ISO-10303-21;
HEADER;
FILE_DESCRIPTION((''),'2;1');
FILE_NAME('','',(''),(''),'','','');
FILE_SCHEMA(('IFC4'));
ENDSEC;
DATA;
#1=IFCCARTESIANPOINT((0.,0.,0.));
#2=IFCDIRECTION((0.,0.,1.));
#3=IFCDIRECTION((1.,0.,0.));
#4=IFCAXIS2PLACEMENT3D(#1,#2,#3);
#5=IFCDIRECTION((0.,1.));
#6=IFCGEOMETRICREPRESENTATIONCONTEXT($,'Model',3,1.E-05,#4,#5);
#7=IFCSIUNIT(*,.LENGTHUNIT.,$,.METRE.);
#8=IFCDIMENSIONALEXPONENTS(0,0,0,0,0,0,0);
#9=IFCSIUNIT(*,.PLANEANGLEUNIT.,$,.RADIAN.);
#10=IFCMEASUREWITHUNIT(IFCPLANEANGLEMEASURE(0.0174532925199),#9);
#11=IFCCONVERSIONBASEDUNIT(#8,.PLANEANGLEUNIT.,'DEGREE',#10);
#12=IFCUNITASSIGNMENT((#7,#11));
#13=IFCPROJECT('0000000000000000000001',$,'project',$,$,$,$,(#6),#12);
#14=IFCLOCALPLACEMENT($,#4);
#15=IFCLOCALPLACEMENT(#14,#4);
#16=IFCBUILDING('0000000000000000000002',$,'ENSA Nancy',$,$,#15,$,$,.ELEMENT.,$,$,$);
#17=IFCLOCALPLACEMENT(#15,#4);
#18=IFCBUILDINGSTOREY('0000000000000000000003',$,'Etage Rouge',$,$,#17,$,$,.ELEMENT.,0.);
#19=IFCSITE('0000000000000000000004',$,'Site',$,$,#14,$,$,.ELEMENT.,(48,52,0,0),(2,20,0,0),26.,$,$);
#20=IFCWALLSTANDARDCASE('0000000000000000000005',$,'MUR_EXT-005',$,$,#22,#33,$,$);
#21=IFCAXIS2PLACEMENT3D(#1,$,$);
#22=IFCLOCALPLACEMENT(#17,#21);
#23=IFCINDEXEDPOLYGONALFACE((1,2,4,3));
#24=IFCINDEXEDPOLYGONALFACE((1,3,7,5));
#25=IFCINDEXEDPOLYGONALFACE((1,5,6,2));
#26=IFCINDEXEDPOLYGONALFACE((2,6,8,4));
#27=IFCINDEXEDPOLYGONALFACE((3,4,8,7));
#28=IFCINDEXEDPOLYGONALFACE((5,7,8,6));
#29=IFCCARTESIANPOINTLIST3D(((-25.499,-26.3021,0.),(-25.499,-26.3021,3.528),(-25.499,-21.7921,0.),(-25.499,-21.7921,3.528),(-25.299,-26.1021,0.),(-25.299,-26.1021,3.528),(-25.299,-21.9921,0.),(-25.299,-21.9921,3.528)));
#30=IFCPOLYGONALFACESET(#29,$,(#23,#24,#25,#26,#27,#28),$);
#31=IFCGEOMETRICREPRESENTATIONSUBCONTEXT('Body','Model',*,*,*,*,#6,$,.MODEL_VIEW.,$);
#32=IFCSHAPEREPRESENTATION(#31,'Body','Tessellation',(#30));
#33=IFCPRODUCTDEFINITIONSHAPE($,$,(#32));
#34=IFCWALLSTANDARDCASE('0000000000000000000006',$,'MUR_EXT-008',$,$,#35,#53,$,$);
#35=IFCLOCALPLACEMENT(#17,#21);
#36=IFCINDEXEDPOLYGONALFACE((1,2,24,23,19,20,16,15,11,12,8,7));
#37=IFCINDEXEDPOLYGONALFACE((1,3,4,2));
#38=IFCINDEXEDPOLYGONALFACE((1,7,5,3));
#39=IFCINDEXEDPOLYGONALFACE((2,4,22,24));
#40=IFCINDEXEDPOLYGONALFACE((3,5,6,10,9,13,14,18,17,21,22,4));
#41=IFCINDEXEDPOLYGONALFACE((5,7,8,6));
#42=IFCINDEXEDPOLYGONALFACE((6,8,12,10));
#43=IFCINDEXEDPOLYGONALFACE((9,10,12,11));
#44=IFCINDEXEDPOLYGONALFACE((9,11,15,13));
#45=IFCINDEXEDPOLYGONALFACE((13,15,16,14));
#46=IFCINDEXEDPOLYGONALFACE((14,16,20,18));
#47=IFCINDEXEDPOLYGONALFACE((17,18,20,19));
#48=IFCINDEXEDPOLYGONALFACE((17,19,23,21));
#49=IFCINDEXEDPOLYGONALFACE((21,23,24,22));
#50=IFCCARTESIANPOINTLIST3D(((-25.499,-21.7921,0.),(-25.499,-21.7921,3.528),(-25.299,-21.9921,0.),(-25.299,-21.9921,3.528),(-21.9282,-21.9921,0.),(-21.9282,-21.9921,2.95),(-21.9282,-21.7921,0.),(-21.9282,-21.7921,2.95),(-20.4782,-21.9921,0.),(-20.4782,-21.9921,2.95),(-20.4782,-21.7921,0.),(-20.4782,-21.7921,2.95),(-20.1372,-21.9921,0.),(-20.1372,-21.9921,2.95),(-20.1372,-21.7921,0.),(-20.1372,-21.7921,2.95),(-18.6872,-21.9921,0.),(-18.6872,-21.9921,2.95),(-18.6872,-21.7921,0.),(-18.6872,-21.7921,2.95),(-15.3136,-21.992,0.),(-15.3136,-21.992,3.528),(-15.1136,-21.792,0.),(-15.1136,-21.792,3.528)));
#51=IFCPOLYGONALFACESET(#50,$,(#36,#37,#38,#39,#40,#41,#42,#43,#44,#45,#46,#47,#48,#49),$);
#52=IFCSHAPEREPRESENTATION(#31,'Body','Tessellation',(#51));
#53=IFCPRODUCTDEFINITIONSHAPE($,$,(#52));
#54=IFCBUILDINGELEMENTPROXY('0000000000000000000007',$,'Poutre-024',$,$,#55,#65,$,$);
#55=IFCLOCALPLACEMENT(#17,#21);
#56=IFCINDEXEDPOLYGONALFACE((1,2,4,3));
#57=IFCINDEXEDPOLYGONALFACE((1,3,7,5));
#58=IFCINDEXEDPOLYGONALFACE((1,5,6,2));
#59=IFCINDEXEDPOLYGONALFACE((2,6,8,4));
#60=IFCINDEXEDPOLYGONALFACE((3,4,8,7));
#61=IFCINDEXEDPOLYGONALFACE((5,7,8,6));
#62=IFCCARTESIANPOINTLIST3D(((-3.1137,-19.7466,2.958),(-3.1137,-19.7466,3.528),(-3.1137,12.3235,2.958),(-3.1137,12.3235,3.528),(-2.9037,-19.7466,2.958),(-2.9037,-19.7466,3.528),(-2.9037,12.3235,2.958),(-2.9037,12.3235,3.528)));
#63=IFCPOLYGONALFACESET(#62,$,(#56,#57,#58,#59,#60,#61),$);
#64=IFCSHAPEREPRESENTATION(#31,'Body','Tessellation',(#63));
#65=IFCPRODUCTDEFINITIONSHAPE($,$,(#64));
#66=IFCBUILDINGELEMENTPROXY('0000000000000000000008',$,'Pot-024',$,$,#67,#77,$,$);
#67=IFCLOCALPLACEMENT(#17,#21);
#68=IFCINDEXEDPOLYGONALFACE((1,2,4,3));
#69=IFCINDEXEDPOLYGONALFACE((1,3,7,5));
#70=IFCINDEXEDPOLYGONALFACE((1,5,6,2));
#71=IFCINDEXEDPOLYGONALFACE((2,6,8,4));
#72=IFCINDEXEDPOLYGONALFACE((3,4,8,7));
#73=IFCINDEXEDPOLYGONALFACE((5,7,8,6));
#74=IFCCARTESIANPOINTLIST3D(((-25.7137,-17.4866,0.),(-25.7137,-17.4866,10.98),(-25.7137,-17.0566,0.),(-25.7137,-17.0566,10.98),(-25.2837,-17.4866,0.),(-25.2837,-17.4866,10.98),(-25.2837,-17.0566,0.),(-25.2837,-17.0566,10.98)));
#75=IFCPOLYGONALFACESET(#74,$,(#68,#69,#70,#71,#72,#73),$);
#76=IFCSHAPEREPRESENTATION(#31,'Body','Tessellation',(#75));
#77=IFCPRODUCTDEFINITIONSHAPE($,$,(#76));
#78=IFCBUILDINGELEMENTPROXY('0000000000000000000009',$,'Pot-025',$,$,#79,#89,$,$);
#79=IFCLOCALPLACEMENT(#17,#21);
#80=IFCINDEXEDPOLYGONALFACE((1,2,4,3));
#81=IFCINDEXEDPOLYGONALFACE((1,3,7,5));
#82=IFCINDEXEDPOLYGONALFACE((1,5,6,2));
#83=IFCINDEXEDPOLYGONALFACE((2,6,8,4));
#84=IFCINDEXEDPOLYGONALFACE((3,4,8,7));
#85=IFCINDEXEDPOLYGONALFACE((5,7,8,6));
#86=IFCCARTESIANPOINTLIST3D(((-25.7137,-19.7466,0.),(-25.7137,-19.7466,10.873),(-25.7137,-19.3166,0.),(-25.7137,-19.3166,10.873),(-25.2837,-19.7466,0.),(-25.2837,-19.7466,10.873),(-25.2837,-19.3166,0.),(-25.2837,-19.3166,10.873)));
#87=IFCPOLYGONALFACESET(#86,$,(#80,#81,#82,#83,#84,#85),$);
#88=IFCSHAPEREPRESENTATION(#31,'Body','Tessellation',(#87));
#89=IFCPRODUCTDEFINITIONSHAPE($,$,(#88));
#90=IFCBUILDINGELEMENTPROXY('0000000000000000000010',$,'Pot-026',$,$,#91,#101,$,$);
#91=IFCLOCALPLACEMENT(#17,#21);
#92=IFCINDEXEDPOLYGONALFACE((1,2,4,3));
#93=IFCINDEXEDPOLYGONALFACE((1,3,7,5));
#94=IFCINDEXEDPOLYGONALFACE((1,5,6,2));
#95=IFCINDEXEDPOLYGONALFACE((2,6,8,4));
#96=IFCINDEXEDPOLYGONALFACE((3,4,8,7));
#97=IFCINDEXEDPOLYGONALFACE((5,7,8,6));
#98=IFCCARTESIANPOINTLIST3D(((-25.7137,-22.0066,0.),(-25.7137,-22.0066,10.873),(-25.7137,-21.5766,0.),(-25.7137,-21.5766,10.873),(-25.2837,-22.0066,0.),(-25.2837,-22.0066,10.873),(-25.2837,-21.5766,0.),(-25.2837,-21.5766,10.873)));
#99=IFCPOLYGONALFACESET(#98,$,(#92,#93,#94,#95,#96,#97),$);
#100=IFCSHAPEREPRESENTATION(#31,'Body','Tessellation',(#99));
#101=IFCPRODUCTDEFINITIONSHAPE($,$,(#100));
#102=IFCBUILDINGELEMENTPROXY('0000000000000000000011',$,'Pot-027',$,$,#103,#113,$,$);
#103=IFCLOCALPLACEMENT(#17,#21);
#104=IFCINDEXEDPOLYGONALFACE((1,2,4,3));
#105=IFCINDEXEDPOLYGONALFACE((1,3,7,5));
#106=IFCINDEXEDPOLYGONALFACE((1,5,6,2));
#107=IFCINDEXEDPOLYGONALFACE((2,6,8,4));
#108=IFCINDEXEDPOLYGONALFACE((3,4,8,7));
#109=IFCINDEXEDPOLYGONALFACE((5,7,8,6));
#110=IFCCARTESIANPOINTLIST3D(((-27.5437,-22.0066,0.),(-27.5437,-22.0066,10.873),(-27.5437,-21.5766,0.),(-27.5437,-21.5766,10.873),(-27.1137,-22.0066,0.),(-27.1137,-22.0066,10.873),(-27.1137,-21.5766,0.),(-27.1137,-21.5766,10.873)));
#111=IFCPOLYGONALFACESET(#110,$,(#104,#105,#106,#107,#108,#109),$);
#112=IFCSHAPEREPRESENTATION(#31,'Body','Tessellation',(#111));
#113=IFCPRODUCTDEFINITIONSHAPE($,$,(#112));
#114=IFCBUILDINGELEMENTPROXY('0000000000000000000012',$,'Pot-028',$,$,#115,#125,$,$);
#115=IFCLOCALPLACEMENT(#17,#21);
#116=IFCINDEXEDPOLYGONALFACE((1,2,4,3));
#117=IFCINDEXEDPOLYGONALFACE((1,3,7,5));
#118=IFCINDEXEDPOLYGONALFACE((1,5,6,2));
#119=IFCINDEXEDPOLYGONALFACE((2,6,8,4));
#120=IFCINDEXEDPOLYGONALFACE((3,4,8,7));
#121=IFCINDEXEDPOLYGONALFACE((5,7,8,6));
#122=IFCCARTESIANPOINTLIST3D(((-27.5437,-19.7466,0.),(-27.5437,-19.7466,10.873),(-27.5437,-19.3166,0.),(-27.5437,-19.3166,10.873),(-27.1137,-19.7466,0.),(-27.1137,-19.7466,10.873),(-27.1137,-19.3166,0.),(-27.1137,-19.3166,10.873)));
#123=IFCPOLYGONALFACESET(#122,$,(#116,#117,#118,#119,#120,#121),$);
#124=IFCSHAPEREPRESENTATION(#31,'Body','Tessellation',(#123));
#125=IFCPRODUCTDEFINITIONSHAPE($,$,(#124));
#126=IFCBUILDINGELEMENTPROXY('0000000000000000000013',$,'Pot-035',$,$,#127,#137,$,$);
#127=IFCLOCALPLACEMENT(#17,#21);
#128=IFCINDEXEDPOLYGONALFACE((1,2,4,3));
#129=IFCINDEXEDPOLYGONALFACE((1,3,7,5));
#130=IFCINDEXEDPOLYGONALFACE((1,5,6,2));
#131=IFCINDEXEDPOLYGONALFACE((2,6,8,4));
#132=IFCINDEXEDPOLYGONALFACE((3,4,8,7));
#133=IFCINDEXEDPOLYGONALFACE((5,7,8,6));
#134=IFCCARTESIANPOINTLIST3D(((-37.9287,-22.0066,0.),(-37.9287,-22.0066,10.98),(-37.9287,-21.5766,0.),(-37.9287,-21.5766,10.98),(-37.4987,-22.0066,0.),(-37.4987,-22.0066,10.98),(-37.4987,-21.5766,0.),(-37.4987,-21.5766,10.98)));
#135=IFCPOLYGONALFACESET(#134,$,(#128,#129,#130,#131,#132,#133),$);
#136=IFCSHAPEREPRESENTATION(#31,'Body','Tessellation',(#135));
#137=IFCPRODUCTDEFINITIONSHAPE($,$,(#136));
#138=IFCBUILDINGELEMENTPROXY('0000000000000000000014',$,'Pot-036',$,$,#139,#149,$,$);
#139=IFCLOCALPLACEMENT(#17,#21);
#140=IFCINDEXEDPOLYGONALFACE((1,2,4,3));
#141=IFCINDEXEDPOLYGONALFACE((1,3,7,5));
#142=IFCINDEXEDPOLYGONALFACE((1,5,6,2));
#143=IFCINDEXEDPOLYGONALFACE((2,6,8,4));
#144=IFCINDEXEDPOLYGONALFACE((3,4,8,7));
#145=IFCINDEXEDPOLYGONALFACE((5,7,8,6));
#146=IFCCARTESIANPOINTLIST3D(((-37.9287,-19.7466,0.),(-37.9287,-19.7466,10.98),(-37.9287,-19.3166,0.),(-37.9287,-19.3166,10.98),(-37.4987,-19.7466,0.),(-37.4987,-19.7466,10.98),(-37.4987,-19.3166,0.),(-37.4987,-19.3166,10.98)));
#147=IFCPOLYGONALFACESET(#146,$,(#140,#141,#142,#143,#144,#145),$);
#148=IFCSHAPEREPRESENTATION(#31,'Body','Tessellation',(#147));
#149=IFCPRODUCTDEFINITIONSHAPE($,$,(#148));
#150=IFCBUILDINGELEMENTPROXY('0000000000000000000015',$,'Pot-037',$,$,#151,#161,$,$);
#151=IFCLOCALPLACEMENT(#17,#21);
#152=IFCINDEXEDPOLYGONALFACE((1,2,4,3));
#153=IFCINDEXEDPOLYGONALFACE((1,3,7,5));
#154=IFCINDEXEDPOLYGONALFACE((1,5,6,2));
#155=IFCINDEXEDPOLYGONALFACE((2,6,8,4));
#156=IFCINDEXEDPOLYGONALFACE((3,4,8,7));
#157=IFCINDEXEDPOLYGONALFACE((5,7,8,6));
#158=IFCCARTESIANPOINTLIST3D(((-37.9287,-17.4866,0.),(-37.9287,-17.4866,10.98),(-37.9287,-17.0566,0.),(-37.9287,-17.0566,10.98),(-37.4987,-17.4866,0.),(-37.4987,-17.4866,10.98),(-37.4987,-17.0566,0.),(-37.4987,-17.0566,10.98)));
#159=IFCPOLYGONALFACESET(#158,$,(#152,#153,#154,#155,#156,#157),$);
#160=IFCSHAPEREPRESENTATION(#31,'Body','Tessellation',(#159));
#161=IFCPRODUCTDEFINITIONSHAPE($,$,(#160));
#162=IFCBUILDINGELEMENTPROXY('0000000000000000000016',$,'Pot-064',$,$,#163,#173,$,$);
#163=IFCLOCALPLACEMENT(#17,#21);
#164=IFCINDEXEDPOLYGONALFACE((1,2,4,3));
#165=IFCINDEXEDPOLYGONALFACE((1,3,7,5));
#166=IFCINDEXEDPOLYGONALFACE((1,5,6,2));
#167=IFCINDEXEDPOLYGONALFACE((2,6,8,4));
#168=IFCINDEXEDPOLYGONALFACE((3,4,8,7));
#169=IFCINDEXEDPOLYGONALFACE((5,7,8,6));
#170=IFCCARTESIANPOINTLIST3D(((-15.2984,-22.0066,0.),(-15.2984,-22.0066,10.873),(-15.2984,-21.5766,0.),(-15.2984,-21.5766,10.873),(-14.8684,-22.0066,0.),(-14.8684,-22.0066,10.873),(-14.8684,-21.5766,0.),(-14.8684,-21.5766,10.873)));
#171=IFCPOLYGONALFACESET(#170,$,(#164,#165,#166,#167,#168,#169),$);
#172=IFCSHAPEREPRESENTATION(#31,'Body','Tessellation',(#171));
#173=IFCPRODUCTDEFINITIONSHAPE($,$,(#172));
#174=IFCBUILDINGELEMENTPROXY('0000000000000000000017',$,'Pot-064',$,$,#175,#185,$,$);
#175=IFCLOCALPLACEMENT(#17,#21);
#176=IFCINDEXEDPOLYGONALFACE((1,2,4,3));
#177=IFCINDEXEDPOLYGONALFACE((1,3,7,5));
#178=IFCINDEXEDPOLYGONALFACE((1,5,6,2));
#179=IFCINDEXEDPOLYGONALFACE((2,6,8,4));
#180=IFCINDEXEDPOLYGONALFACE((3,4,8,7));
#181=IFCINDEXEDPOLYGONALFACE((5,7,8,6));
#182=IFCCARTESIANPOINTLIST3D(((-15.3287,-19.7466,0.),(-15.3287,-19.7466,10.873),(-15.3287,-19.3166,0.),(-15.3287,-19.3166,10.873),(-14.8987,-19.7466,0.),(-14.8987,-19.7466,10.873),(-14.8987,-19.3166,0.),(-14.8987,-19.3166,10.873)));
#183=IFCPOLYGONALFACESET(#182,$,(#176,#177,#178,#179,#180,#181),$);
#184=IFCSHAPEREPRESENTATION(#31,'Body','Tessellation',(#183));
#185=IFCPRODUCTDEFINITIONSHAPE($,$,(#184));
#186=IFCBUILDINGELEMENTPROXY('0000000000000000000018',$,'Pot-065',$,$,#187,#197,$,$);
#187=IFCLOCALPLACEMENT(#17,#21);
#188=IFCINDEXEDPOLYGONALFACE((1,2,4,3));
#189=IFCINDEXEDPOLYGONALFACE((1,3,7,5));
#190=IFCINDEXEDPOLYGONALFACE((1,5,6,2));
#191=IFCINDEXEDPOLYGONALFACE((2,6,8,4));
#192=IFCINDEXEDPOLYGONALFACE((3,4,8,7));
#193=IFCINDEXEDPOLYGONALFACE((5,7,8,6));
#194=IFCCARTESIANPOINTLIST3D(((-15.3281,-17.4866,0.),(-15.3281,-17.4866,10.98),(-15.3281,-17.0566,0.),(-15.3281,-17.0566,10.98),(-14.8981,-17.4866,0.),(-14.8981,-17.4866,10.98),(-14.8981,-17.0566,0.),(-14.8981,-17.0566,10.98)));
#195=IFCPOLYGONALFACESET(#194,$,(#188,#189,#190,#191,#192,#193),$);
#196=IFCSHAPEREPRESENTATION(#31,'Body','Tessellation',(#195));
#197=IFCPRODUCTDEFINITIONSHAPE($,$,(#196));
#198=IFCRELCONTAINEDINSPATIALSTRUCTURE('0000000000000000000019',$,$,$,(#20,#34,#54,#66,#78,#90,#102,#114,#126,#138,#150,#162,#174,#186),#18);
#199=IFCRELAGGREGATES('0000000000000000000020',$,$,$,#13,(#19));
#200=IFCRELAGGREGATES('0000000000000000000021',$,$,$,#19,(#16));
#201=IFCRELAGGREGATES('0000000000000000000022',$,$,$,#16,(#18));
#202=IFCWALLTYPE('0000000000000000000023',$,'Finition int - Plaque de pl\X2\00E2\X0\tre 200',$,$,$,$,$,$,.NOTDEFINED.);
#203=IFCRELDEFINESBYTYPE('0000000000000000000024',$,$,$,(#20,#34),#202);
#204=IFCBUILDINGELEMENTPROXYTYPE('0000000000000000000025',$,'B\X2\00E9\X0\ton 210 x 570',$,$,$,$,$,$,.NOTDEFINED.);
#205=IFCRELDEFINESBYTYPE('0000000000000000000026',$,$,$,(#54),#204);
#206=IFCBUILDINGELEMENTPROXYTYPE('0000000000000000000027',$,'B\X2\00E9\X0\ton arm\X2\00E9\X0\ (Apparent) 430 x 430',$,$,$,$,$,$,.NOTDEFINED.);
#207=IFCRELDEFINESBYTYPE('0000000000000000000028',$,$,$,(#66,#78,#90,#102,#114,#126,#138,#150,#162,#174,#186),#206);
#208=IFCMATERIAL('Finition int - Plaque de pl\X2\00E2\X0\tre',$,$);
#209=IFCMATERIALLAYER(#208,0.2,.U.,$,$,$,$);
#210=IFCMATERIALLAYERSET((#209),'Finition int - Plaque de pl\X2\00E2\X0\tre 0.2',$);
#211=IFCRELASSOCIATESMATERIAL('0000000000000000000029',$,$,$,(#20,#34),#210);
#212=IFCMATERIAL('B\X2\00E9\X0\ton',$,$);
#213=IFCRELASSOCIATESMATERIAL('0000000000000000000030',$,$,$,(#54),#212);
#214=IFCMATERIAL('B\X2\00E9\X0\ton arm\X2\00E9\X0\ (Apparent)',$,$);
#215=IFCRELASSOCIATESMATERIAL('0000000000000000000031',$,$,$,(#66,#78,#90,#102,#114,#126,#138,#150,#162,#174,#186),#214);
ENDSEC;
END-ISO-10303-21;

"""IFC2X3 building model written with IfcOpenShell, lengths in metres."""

from ifc_helpers import new_model, entity, si_unit, converted_unit, direction, frame, frame_2d, origin_with_axes, origin_2d_with_axis, place, context, subcontext, project, spatial, polyline, rectangle, outline, extrude, material, layer, layer_set, layer_usage, type_object, element, save


model = new_model("IFC2X3")

# Units and contexts
model_context = context("Model", 3, precision=1e-05, world=origin_with_axes(), true_north=direction((0.0, 1.0)))
body_context = subcontext(model_context, "Body", "Model", "MODEL_VIEW")
ifc_project = project(units=[si_unit("LENGTHUNIT", "METRE"), converted_unit("PLANEANGLEUNIT", "DEGREE", entity("IfcPlaneAngleMeasure", 0.0174532925199), si_unit("PLANEANGLEUNIT", "RADIAN"), dimensions=[0, 0, 0, 0, 0, 0, 0])], contexts=[model_context])

# Site, building, storey
site_placement = place(None, origin_with_axes())
site = spatial("IfcSite", under=ifc_project, at=site_placement, Name="Site", CompositionType="ELEMENT", RefLatitude=(48, 52, 0, 0), RefLongitude=(2, 20, 0, 0), RefElevation=26.0)
building_placement = place(site_placement, origin_with_axes())
building = spatial("IfcBuilding", under=site, at=building_placement, Name="ENSA Nancy", CompositionType="ELEMENT")
storey_placement = place(building_placement, origin_with_axes())
storey = spatial("IfcBuildingStorey", under=building, at=storey_placement, Name="Etage Rouge", CompositionType="ELEMENT", Elevation=0.0)

# Wall
ifc_material_1 = material(Name="Finition int - Plaque de plâtre")
ifc_layer = layer(ifc_material_1, 0.2, ventilated="UNKNOWN")
ifc_layer_set = layer_set([ifc_layer], Name="Finition int - Plaque de plâtre 0.2")
ifc_layer_usage_1 = layer_usage(ifc_layer_set, "AXIS2", "POSITIVE", 0.0)
wall_type = type_object("IfcWallType", Name="Finition int - Plaque de plâtre 200", PredefinedType="NOTDEFINED")
wall_1_placement = place(storey_placement, frame((-25.499, -21.7921, 0.0), z_axis=(0.0, 0.0, 1.0), x_axis=(0.0, -1.0, 0.0)))
element("IfcWallStandardCase", 1, at=wall_1_placement, inside=storey, type_object=wall_type, material=ifc_layer_usage_1, Name="MUR_EXT-005", context=body_context, shape_type="SweptSolid", body=[
    extrude(outline(polyline([(0.0, 0.0), (4.51, 0.0), (4.31, 0.2), (0.2, 0.2), (0.0, 0.0)])), origin_with_axes(), (0.0, 0.0, 1.0), 3.528),
])

# Wall, openings
ifc_layer_usage_2 = layer_usage(ifc_layer_set, "AXIS2", "POSITIVE", 0.0)
wall_2_placement = place(storey_placement, frame((-15.1136, -21.792, 0.0), z_axis=(0.0, 0.0, 1.0), x_axis=(-1.0, -0.000003, 0.0)))
wall_2 = element("IfcWallStandardCase", 2, at=wall_2_placement, inside=storey, type_object=wall_type, material=ifc_layer_usage_2, Name="MUR_EXT-008", context=body_context, shape_type="SweptSolid", body=[
    extrude(outline(polyline([(0.0, 0.0), (10.3854, 0.0), (10.1854, 0.2), (0.2, 0.2), (0.0, 0.0)])), origin_with_axes(), (0.0, 0.0, 1.0), 3.528),
])
opening_1_placement = place(wall_2_placement, frame((6.0896, 0.0, 0.0), z_axis=(0.0, 0.0, 1.0), x_axis=(1.0, 0.0, 0.0)))
element("IfcOpeningElement", 3, at=opening_1_placement, cuts=wall_2, context=body_context, shape_type="SweptSolid", body=[
    extrude(rectangle(XDim=1.45, YDim=2.95, at=origin_2d_with_axis()), frame((0.0, 0.2, 1.475), z_axis=(0.0, 1.0, 0.0), x_axis=(1.0, 0.0, 0.0)), (0.0, 0.0, -1.0), 0.6),
])
opening_2_placement = place(wall_2_placement, frame((4.2986, 0.0, 0.0), z_axis=(0.0, 0.0, 1.0), x_axis=(1.0, 0.0, 0.0)))
element("IfcOpeningElement", 4, at=opening_2_placement, cuts=wall_2, context=body_context, shape_type="SweptSolid", body=[
    extrude(rectangle(XDim=1.45, YDim=2.95, at=origin_2d_with_axis()), frame((0.0, 0.2, 1.475), z_axis=(0.0, -1.0, 0.0), x_axis=(-1.0, 0.0, 0.0)), (0.0, 0.0, 1.0), 0.6),
])

# Building element proxies
ifc_material_2 = material(Name="Béton")
building_element_proxy_type_1 = type_object("IfcBuildingElementProxyType", Name="Béton 210 x 570", PredefinedType="NOTDEFINED")
proxy_1_placement = place(storey_placement, frame((-3.0087, -19.7466, 3.528), z_axis=(0.0, 0.0, 1.0), x_axis=(1.0, 0.0, 0.0)))
element("IfcBuildingElementProxy", 5, at=proxy_1_placement, inside=storey, type_object=building_element_proxy_type_1, material=ifc_material_2, Name="Poutre-024", context=body_context, shape_type="SweptSolid", body=[
    extrude(rectangle(XDim=0.57, YDim=0.21, at=frame_2d((-0.285, 0.0), x_axis=(1.0, 0.0))), frame((0.0, 0.0, 0.0), z_axis=(0.0, 1.0, 0.0), x_axis=(0.0, 0.0, 1.0)), (0.0, 0.0, 1.0), 32.07),
])
ifc_material_3 = material(Name="Béton armé (Apparent)")
building_element_proxy_type_2 = type_object("IfcBuildingElementProxyType", Name="Béton armé (Apparent) 430 x 430", PredefinedType="NOTDEFINED")
proxy_2_placement = place(storey_placement, frame((-25.4987, -17.2716, 0.0), z_axis=(0.0, 0.0, 1.0), x_axis=(1.0, 0.0, 0.0)))
element("IfcBuildingElementProxy", 6, at=proxy_2_placement, inside=storey, type_object=building_element_proxy_type_2, material=ifc_material_3, Name="Pot-024", context=body_context, shape_type="SweptSolid", body=[
    extrude(rectangle(XDim=0.43, YDim=0.43, at=origin_2d_with_axis()), origin_with_axes(), (0.0, 0.0, 1.0), 10.98),
])
for number, where, z_axis, x_axis, name in (
    (7, (-25.4987, -19.5316, 0.0), (0.0, 0.0, 1.0), (1.0, 0.0, 0.0), "Pot-025"),
    (8, (-25.4987, -21.7916, 0.0), (0.0, 0.0, 1.0), (1.0, 0.0, 0.0), "Pot-026"),
    (9, (-27.3287, -21.7916, 0.0), (0.0, 0.0, 1.0), (1.0, 0.0, 0.0), "Pot-027"),
    (10, (-27.3287, -19.5316, 0.0), (0.0, 0.0, 1.0), (1.0, 0.0, 0.0), "Pot-028"),
):
    element("IfcBuildingElementProxy", number, at=place(storey_placement, frame(where, z_axis=z_axis, x_axis=x_axis)), inside=storey, type_object=building_element_proxy_type_2, material=ifc_material_3, Name=name, context=body_context, shape_type="SweptSolid", body=[
        extrude(rectangle(XDim=0.43, YDim=0.43, at=origin_2d_with_axis()), origin_with_axes(), (0.0, 0.0, 1.0), 10.873),
    ])
for number, where, z_axis, x_axis, name in (
    (11, (-37.7137, -21.7916, 0.0), (0.0, 0.0, 1.0), (1.0, 0.0, 0.0), "Pot-035"),
    (12, (-37.7137, -19.5316, 0.0), (0.0, 0.0, 1.0), (1.0, 0.0, 0.0), "Pot-036"),
    (13, (-37.7137, -17.2716, 0.0), (0.0, 0.0, 1.0), (1.0, 0.0, 0.0), "Pot-037"),
):
    element("IfcBuildingElementProxy", number, at=place(storey_placement, frame(where, z_axis=z_axis, x_axis=x_axis)), inside=storey, type_object=building_element_proxy_type_2, material=ifc_material_3, Name=name, context=body_context, shape_type="SweptSolid", body=[
        extrude(rectangle(XDim=0.43, YDim=0.43, at=origin_2d_with_axis()), origin_with_axes(), (0.0, 0.0, 1.0), 10.98),
    ])
for number, where, z_axis, x_axis, name in (
    (14, (-15.0834, -21.7916, 0.0), (0.0, 0.0, 1.0), (1.0, 0.0, 0.0), "Pot-064"),
    (15, (-15.1137, -19.5316, 0.0), (0.0, 0.0, 1.0), (1.0, 0.0, 0.0), "Pot-064"),
):
    element("IfcBuildingElementProxy", number, at=place(storey_placement, frame(where, z_axis=z_axis, x_axis=x_axis)), inside=storey, type_object=building_element_proxy_type_2, material=ifc_material_3, Name=name, context=body_context, shape_type="SweptSolid", body=[
        extrude(rectangle(XDim=0.43, YDim=0.43, at=origin_2d_with_axis()), origin_with_axes(), (0.0, 0.0, 1.0), 10.873),
    ])
proxy_3_placement = place(storey_placement, frame((-15.1131, -17.2716, 0.0), z_axis=(0.0, 0.0, 1.0), x_axis=(1.0, 0.0, 0.0)))
element("IfcBuildingElementProxy", 16, at=proxy_3_placement, inside=storey, type_object=building_element_proxy_type_2, material=ifc_material_3, Name="Pot-065", context=body_context, shape_type="SweptSolid", body=[
    extrude(rectangle(XDim=0.43, YDim=0.43, at=origin_2d_with_axis()), origin_with_axes(), (0.0, 0.0, 1.0), 10.98),
])

save(model, "model.ifc")
